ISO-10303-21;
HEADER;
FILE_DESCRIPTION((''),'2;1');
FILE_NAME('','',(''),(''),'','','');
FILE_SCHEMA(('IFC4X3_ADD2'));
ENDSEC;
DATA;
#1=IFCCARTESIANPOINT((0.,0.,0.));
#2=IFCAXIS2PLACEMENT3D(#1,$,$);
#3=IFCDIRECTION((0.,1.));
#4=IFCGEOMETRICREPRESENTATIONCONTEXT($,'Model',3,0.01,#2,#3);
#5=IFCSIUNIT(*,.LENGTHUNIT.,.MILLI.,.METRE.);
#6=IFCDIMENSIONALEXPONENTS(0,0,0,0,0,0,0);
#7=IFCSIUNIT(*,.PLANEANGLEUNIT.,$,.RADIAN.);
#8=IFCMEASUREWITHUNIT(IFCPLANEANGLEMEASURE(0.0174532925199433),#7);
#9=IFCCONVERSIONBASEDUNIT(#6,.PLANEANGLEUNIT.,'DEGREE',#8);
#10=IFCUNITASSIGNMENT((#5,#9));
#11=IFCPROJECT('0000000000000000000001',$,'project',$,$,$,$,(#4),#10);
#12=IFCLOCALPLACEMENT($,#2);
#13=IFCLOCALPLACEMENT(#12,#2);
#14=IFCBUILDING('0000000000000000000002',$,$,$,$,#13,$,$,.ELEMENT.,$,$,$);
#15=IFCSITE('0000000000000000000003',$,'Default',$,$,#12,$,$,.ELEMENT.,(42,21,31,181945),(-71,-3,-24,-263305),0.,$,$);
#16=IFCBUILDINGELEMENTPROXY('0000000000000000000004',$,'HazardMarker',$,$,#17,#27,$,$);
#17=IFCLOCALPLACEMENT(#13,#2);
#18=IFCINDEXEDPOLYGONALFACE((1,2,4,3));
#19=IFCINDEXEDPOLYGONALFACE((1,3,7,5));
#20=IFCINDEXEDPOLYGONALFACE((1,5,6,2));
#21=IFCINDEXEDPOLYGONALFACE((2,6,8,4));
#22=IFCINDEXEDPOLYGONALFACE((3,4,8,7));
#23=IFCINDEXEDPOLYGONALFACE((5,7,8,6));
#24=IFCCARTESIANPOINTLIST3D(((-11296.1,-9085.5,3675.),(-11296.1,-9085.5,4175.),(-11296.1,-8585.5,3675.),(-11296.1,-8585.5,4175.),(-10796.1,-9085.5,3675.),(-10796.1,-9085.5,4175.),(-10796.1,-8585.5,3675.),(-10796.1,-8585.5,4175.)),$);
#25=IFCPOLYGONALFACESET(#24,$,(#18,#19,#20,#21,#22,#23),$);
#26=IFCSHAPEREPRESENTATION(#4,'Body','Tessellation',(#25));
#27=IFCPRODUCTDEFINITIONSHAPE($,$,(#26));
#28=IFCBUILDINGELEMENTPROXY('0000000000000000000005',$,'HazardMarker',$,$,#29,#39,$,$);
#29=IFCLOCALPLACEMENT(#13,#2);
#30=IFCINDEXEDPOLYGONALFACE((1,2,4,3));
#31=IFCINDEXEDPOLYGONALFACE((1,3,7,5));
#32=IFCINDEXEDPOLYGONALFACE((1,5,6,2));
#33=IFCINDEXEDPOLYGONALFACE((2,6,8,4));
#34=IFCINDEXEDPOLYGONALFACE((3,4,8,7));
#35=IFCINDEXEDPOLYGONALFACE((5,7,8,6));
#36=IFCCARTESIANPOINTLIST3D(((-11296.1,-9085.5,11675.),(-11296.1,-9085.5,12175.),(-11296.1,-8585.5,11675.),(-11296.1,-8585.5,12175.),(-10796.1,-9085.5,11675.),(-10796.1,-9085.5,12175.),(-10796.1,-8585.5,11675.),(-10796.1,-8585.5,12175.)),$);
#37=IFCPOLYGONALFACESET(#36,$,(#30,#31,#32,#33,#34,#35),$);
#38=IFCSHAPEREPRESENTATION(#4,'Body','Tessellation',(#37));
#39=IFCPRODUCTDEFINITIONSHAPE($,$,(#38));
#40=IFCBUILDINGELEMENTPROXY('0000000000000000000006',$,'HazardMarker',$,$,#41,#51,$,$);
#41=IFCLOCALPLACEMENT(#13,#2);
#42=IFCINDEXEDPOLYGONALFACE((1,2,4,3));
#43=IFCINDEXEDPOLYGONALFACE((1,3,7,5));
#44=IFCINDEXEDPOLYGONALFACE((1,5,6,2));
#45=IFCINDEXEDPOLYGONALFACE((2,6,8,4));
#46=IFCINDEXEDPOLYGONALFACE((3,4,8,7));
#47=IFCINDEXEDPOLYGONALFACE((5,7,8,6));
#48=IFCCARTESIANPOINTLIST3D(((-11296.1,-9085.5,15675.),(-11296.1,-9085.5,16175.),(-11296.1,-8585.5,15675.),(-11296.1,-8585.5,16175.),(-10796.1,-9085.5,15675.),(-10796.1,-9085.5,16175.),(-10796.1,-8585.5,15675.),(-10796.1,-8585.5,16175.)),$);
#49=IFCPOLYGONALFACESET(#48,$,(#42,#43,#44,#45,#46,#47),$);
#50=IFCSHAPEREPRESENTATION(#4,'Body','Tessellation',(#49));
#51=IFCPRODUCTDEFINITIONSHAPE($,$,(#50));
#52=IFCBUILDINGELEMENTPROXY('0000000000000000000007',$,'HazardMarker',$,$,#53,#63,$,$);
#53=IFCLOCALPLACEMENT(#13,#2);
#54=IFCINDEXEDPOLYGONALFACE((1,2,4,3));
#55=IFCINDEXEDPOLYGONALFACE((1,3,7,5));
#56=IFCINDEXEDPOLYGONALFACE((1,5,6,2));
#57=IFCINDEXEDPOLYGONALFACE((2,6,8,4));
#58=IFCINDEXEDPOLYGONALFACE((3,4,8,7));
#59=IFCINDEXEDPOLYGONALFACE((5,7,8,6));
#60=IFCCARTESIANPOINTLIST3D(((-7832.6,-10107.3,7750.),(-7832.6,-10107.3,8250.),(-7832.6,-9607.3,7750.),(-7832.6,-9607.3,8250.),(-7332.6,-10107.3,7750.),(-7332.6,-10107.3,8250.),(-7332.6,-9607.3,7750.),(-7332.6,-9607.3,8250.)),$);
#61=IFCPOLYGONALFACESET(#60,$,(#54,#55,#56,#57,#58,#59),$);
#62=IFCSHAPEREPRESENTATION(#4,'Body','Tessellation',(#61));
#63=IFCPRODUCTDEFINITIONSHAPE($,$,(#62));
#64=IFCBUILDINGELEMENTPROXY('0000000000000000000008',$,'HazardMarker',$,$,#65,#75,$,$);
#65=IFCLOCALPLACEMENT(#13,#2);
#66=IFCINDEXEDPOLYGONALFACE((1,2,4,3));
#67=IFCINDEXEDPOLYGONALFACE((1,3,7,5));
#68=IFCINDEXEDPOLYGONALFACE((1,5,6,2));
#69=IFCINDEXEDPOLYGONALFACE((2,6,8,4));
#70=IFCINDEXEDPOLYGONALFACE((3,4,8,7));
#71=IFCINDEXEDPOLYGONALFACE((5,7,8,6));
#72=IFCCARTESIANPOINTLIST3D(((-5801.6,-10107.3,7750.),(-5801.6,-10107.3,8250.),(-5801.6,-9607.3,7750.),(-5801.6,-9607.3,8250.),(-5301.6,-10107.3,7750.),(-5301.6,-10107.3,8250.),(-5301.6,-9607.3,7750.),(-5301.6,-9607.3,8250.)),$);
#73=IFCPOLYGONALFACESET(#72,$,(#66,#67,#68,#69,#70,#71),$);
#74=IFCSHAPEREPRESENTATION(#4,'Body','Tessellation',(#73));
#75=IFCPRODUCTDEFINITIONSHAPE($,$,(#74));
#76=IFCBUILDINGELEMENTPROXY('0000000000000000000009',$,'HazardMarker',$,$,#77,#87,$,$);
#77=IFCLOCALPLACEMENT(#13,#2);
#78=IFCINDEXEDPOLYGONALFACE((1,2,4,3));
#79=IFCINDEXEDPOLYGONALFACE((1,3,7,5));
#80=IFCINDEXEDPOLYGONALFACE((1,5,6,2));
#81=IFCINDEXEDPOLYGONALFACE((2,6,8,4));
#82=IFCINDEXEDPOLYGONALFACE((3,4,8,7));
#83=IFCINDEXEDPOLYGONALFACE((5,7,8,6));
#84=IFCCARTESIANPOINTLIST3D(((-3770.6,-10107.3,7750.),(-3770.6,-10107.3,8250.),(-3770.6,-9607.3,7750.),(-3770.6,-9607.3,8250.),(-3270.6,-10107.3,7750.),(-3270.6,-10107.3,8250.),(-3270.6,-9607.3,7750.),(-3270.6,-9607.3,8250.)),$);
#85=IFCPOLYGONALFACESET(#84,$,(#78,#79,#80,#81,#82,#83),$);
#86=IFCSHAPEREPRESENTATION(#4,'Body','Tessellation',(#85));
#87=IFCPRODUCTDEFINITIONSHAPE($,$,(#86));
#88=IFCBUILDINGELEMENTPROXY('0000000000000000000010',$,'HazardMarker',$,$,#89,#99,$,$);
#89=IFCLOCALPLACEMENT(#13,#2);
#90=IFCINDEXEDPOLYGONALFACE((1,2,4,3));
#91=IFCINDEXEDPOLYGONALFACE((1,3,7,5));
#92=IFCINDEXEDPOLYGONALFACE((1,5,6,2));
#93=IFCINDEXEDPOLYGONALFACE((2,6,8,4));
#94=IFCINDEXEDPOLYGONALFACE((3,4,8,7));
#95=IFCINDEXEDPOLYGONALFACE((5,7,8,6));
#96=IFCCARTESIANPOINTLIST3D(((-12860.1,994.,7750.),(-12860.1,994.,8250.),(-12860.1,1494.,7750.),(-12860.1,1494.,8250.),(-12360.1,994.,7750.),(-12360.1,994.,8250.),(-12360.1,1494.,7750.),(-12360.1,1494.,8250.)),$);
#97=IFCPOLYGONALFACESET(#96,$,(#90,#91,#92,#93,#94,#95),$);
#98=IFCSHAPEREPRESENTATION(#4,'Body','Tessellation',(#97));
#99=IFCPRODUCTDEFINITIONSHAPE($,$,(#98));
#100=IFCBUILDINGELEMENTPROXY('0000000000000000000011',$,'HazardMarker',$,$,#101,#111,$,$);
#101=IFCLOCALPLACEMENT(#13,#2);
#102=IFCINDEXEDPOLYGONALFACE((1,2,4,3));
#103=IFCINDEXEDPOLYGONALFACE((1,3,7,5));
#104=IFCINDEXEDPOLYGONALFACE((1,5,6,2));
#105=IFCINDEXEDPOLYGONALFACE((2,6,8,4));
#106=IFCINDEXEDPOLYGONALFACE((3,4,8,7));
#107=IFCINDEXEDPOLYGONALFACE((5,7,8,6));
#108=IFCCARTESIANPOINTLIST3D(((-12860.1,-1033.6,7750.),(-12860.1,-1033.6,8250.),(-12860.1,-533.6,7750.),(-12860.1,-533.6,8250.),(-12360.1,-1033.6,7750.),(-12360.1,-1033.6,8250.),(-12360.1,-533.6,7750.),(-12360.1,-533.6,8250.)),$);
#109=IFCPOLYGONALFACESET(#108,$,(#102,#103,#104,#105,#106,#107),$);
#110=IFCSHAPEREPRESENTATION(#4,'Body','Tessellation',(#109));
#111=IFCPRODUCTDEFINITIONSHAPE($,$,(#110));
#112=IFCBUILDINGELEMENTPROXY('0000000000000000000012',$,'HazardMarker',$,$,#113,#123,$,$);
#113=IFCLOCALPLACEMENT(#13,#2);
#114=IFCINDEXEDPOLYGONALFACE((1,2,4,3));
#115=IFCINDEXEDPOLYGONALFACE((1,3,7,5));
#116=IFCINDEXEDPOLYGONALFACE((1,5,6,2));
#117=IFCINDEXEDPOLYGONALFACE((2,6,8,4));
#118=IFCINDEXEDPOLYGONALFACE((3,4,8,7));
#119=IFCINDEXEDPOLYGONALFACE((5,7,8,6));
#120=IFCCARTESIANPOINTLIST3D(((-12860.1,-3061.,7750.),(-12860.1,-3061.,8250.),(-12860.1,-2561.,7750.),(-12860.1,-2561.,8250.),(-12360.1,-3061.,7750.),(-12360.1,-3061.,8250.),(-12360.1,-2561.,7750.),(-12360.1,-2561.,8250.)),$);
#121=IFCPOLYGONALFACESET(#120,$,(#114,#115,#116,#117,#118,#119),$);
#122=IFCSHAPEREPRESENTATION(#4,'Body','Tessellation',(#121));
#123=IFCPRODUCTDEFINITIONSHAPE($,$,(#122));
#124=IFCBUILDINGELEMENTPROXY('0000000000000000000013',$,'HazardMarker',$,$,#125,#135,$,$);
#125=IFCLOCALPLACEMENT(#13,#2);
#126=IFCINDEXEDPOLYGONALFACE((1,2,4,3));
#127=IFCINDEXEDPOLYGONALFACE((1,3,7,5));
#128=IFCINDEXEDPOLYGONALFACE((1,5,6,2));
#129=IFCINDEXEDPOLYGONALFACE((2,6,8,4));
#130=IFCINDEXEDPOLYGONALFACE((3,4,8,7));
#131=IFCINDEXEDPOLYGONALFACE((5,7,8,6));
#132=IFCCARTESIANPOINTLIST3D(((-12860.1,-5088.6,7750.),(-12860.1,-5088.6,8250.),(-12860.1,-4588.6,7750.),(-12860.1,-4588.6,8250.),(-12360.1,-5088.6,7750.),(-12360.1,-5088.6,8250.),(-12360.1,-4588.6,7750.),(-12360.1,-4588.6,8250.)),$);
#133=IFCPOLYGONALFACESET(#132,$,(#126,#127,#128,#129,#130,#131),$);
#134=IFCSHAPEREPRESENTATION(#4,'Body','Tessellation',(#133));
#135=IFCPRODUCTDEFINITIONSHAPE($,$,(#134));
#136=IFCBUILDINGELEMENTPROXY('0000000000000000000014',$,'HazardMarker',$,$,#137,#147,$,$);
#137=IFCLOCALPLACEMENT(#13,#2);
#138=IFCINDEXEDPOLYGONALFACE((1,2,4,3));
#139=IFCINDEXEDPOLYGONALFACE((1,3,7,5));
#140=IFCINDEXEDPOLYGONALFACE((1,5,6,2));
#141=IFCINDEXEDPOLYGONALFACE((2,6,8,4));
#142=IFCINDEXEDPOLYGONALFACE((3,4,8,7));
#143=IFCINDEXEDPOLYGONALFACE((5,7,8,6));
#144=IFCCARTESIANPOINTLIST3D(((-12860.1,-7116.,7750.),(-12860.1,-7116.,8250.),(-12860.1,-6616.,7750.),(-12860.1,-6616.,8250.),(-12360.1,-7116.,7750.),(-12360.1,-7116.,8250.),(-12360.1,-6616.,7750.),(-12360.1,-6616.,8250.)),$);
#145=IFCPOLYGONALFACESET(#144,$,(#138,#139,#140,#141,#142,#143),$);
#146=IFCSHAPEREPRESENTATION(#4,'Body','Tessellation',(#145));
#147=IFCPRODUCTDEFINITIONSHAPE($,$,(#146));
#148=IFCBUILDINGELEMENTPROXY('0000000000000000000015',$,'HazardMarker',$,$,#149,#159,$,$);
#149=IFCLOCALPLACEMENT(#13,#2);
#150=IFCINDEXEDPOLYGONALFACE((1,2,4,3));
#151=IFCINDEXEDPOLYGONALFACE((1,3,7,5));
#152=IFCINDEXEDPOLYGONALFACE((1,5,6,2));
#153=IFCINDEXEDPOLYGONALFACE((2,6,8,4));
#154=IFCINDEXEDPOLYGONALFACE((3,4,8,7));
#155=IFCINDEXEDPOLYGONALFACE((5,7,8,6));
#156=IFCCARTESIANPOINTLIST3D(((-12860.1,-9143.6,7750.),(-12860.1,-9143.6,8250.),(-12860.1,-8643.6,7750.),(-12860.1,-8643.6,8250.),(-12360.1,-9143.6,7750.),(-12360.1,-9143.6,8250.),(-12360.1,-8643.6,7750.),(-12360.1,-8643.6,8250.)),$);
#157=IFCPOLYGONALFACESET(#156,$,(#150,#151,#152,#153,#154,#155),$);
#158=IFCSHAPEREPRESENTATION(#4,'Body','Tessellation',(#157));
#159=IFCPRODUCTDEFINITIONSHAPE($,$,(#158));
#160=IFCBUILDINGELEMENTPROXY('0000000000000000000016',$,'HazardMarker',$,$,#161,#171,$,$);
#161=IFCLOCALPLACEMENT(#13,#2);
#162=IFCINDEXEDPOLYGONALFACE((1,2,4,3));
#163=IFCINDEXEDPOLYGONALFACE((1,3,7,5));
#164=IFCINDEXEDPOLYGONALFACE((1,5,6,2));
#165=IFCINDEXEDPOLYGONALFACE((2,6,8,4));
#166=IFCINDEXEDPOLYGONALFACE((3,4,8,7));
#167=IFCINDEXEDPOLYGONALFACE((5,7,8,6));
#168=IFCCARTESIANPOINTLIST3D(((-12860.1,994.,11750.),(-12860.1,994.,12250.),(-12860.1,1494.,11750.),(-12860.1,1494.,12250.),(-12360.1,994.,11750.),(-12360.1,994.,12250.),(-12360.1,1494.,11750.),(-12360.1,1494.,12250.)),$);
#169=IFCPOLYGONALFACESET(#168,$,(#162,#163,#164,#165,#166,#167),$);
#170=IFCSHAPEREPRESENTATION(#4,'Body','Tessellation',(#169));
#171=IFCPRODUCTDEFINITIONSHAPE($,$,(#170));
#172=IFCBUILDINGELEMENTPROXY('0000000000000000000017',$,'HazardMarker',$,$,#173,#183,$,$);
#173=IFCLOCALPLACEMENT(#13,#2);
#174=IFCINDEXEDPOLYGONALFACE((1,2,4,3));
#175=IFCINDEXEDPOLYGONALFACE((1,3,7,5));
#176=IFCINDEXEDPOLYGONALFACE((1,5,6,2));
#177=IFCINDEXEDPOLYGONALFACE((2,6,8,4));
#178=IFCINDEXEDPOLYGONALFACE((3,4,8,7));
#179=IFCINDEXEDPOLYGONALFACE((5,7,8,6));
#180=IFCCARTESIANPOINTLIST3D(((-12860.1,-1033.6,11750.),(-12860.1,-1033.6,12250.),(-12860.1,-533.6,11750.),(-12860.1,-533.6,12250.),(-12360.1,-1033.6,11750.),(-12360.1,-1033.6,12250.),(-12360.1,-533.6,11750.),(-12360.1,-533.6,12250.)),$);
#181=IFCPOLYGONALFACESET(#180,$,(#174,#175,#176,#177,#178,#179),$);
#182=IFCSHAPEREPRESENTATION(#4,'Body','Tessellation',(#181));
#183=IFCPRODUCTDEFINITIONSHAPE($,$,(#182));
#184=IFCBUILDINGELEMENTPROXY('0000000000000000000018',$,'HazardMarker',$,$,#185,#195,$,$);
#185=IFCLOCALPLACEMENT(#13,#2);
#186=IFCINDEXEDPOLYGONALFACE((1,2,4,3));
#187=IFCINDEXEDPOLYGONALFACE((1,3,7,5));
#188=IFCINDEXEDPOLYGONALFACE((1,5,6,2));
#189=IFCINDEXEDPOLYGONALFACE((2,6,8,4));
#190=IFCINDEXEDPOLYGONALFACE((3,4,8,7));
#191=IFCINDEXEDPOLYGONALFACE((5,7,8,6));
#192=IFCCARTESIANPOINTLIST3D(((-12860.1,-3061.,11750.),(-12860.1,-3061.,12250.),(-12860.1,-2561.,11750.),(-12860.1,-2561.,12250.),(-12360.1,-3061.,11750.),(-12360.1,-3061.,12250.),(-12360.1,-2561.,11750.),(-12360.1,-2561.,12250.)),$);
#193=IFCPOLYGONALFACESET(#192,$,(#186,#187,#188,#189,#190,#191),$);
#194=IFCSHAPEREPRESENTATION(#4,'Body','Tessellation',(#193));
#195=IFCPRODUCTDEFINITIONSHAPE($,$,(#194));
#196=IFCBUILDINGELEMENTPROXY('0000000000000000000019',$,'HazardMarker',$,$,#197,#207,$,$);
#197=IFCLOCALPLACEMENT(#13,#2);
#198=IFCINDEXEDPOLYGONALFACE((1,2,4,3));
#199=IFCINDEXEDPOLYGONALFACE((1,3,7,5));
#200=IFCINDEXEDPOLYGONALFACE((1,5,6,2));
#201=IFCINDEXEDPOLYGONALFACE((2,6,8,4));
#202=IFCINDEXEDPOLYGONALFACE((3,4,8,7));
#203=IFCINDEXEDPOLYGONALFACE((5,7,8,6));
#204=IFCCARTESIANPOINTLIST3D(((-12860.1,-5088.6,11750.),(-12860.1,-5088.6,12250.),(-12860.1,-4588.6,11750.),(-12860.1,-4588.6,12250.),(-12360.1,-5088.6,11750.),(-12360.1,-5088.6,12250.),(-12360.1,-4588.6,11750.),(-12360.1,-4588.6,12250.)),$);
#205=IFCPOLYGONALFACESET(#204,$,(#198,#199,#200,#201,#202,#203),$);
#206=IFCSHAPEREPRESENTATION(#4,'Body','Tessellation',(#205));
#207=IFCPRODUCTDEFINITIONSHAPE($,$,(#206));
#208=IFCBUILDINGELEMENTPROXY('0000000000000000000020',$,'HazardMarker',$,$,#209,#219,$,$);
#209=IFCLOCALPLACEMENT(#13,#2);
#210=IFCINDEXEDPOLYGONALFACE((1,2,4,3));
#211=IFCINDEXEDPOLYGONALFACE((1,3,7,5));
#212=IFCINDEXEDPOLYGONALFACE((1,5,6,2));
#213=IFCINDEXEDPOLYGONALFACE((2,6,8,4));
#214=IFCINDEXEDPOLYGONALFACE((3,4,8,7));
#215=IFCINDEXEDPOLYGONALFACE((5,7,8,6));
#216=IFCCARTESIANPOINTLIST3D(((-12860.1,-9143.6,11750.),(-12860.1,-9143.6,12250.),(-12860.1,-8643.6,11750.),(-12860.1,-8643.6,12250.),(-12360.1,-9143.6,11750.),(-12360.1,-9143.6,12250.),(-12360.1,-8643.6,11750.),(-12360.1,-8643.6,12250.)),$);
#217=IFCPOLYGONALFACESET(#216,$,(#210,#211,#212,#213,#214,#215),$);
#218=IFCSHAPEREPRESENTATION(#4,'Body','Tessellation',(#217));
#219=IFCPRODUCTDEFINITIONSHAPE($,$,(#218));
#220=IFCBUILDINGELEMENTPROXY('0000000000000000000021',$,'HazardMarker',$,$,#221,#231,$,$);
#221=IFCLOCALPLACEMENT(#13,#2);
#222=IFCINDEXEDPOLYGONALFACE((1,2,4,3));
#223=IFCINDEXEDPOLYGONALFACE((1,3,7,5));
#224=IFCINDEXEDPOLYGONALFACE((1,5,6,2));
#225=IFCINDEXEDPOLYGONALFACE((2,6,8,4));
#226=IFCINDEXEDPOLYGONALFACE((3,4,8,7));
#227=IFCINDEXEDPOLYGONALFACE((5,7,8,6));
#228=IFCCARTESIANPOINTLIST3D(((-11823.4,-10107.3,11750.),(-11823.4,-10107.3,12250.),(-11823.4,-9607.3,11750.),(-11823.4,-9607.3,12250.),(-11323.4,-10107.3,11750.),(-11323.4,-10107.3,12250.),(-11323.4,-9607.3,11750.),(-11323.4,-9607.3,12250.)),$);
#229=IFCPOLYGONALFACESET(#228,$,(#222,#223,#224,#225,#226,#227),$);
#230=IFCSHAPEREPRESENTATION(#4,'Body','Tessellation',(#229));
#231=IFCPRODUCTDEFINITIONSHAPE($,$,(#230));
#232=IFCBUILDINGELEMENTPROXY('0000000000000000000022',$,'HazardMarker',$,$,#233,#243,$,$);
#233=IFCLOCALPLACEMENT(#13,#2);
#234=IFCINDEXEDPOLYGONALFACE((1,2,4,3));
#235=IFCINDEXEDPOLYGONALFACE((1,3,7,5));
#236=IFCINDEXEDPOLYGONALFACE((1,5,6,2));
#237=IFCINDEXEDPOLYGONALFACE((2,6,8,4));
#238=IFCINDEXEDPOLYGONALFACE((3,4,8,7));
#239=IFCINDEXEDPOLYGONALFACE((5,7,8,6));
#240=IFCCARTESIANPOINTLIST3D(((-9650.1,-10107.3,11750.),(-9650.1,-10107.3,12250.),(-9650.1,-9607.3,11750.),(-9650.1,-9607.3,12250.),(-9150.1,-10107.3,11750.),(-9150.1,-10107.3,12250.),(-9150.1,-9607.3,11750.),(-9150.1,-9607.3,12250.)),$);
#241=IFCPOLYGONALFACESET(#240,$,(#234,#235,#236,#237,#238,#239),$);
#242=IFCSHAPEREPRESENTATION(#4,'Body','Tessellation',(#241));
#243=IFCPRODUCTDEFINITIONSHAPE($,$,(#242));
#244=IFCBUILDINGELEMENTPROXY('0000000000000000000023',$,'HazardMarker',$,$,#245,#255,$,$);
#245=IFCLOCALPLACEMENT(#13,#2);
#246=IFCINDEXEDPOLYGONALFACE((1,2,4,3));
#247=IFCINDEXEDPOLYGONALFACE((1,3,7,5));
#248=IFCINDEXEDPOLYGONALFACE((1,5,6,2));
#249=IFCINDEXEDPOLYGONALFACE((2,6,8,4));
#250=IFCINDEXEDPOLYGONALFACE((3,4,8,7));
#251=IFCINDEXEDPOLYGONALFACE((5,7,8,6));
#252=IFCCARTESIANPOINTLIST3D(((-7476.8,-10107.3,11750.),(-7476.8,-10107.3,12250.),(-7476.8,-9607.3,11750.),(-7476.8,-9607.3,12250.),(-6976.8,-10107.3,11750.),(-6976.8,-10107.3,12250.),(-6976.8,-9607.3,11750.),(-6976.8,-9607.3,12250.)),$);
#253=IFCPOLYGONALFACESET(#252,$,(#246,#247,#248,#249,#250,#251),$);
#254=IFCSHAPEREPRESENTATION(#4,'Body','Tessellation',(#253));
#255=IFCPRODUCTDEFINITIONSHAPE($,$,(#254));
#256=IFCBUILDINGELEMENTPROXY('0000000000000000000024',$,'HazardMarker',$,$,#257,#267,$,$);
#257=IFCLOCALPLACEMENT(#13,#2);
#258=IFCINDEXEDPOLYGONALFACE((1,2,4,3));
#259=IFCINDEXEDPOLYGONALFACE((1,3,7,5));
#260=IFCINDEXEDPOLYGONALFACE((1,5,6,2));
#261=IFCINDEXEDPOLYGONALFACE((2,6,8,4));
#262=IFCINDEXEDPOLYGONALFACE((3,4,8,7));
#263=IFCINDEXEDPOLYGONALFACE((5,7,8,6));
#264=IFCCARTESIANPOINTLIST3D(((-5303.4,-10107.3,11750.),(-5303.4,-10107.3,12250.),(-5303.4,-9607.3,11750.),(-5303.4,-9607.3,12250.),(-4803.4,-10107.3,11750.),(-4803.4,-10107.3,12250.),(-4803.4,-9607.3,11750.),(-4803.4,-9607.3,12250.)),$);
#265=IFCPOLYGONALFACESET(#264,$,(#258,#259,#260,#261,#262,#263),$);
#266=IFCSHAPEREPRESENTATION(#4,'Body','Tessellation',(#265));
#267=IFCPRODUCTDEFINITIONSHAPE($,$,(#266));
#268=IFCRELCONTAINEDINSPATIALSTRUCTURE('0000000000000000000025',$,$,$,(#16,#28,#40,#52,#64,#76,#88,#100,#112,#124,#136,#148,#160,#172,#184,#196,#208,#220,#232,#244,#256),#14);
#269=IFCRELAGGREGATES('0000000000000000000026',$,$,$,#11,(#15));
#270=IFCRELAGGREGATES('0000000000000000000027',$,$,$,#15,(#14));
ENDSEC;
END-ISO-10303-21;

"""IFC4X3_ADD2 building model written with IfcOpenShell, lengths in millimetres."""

from ifc_helpers import new_model, entity, si_unit, converted_unit, direction, frame, origin, place, context, project, spatial, rectangle, extrude, element, save


model = new_model("IFC4X3_ADD2")

# Units and contexts
model_context = context("Model", 3, precision=0.01, world=origin(), true_north=direction((0.0, 1.0)))
ifc_project = project(units=[si_unit("LENGTHUNIT", "METRE", prefix="MILLI"), converted_unit("PLANEANGLEUNIT", "DEGREE", entity("IfcPlaneAngleMeasure", 0.0174532925199433), si_unit("PLANEANGLEUNIT", "RADIAN"), dimensions=[0, 0, 0, 0, 0, 0, 0])], contexts=[model_context])

# Site, building
site_placement = place(None, origin())
site = spatial("IfcSite", under=ifc_project, at=site_placement, Name="Default", CompositionType="ELEMENT", RefLatitude=(42, 21, 31, 181945), RefLongitude=(-71, -3, -24, -263305), RefElevation=0.0)
building_placement = place(site_placement, origin())
building = spatial("IfcBuilding", under=site, at=building_placement, CompositionType="ELEMENT")

# Building element proxies
for number, where, name in (
    (1, (-11046.1, -8835.5, 3925.0), "HazardMarker"),
    (2, (-11046.1, -8835.5, 11925.0), "HazardMarker"),
    (3, (-11046.1, -8835.5, 15925.0), "HazardMarker"),
    (4, (-7582.6, -9857.3, 8000.0), "HazardMarker"),
    (5, (-5551.6, -9857.3, 8000.0), "HazardMarker"),
    (6, (-3520.6, -9857.3, 8000.0), "HazardMarker"),
    (7, (-12610.1, 1244.0, 8000.0), "HazardMarker"),
    (8, (-12610.1, -783.5, 8000.0), "HazardMarker"),
    (9, (-12610.1, -2811.1, 8000.0), "HazardMarker"),
    (10, (-12610.1, -4838.6, 8000.0), "HazardMarker"),
    (11, (-12610.1, -6866.1, 8000.0), "HazardMarker"),
    (12, (-12610.1, -8893.5, 8000.0), "HazardMarker"),
    (13, (-12610.1, 1244.0, 12000.0), "HazardMarker"),
    (14, (-12610.1, -783.5, 12000.0), "HazardMarker"),
    (15, (-12610.1, -2811.1, 12000.0), "HazardMarker"),
    (16, (-12610.1, -4838.6, 12000.0), "HazardMarker"),
    (17, (-12610.1, -8893.5, 12000.0), "HazardMarker"),
    (18, (-11573.4, -9857.3, 12000.0), "HazardMarker"),
    (19, (-9400.1, -9857.3, 12000.0), "HazardMarker"),
    (20, (-7226.8, -9857.3, 12000.0), "HazardMarker"),
    (21, (-5053.4, -9857.3, 12000.0), "HazardMarker"),
):
    element("IfcBuildingElementProxy", number, at=place(None, frame(where)), inside=building, Name=name, context=model_context, shape_type="SweptSolid", body=[
        extrude(rectangle(XDim=500.0, YDim=500.0), frame((0.0, 0.0, -250.0)), (0.0, 0.0, 1.0), 500.0),
    ])

save(model, "model.ifc")
